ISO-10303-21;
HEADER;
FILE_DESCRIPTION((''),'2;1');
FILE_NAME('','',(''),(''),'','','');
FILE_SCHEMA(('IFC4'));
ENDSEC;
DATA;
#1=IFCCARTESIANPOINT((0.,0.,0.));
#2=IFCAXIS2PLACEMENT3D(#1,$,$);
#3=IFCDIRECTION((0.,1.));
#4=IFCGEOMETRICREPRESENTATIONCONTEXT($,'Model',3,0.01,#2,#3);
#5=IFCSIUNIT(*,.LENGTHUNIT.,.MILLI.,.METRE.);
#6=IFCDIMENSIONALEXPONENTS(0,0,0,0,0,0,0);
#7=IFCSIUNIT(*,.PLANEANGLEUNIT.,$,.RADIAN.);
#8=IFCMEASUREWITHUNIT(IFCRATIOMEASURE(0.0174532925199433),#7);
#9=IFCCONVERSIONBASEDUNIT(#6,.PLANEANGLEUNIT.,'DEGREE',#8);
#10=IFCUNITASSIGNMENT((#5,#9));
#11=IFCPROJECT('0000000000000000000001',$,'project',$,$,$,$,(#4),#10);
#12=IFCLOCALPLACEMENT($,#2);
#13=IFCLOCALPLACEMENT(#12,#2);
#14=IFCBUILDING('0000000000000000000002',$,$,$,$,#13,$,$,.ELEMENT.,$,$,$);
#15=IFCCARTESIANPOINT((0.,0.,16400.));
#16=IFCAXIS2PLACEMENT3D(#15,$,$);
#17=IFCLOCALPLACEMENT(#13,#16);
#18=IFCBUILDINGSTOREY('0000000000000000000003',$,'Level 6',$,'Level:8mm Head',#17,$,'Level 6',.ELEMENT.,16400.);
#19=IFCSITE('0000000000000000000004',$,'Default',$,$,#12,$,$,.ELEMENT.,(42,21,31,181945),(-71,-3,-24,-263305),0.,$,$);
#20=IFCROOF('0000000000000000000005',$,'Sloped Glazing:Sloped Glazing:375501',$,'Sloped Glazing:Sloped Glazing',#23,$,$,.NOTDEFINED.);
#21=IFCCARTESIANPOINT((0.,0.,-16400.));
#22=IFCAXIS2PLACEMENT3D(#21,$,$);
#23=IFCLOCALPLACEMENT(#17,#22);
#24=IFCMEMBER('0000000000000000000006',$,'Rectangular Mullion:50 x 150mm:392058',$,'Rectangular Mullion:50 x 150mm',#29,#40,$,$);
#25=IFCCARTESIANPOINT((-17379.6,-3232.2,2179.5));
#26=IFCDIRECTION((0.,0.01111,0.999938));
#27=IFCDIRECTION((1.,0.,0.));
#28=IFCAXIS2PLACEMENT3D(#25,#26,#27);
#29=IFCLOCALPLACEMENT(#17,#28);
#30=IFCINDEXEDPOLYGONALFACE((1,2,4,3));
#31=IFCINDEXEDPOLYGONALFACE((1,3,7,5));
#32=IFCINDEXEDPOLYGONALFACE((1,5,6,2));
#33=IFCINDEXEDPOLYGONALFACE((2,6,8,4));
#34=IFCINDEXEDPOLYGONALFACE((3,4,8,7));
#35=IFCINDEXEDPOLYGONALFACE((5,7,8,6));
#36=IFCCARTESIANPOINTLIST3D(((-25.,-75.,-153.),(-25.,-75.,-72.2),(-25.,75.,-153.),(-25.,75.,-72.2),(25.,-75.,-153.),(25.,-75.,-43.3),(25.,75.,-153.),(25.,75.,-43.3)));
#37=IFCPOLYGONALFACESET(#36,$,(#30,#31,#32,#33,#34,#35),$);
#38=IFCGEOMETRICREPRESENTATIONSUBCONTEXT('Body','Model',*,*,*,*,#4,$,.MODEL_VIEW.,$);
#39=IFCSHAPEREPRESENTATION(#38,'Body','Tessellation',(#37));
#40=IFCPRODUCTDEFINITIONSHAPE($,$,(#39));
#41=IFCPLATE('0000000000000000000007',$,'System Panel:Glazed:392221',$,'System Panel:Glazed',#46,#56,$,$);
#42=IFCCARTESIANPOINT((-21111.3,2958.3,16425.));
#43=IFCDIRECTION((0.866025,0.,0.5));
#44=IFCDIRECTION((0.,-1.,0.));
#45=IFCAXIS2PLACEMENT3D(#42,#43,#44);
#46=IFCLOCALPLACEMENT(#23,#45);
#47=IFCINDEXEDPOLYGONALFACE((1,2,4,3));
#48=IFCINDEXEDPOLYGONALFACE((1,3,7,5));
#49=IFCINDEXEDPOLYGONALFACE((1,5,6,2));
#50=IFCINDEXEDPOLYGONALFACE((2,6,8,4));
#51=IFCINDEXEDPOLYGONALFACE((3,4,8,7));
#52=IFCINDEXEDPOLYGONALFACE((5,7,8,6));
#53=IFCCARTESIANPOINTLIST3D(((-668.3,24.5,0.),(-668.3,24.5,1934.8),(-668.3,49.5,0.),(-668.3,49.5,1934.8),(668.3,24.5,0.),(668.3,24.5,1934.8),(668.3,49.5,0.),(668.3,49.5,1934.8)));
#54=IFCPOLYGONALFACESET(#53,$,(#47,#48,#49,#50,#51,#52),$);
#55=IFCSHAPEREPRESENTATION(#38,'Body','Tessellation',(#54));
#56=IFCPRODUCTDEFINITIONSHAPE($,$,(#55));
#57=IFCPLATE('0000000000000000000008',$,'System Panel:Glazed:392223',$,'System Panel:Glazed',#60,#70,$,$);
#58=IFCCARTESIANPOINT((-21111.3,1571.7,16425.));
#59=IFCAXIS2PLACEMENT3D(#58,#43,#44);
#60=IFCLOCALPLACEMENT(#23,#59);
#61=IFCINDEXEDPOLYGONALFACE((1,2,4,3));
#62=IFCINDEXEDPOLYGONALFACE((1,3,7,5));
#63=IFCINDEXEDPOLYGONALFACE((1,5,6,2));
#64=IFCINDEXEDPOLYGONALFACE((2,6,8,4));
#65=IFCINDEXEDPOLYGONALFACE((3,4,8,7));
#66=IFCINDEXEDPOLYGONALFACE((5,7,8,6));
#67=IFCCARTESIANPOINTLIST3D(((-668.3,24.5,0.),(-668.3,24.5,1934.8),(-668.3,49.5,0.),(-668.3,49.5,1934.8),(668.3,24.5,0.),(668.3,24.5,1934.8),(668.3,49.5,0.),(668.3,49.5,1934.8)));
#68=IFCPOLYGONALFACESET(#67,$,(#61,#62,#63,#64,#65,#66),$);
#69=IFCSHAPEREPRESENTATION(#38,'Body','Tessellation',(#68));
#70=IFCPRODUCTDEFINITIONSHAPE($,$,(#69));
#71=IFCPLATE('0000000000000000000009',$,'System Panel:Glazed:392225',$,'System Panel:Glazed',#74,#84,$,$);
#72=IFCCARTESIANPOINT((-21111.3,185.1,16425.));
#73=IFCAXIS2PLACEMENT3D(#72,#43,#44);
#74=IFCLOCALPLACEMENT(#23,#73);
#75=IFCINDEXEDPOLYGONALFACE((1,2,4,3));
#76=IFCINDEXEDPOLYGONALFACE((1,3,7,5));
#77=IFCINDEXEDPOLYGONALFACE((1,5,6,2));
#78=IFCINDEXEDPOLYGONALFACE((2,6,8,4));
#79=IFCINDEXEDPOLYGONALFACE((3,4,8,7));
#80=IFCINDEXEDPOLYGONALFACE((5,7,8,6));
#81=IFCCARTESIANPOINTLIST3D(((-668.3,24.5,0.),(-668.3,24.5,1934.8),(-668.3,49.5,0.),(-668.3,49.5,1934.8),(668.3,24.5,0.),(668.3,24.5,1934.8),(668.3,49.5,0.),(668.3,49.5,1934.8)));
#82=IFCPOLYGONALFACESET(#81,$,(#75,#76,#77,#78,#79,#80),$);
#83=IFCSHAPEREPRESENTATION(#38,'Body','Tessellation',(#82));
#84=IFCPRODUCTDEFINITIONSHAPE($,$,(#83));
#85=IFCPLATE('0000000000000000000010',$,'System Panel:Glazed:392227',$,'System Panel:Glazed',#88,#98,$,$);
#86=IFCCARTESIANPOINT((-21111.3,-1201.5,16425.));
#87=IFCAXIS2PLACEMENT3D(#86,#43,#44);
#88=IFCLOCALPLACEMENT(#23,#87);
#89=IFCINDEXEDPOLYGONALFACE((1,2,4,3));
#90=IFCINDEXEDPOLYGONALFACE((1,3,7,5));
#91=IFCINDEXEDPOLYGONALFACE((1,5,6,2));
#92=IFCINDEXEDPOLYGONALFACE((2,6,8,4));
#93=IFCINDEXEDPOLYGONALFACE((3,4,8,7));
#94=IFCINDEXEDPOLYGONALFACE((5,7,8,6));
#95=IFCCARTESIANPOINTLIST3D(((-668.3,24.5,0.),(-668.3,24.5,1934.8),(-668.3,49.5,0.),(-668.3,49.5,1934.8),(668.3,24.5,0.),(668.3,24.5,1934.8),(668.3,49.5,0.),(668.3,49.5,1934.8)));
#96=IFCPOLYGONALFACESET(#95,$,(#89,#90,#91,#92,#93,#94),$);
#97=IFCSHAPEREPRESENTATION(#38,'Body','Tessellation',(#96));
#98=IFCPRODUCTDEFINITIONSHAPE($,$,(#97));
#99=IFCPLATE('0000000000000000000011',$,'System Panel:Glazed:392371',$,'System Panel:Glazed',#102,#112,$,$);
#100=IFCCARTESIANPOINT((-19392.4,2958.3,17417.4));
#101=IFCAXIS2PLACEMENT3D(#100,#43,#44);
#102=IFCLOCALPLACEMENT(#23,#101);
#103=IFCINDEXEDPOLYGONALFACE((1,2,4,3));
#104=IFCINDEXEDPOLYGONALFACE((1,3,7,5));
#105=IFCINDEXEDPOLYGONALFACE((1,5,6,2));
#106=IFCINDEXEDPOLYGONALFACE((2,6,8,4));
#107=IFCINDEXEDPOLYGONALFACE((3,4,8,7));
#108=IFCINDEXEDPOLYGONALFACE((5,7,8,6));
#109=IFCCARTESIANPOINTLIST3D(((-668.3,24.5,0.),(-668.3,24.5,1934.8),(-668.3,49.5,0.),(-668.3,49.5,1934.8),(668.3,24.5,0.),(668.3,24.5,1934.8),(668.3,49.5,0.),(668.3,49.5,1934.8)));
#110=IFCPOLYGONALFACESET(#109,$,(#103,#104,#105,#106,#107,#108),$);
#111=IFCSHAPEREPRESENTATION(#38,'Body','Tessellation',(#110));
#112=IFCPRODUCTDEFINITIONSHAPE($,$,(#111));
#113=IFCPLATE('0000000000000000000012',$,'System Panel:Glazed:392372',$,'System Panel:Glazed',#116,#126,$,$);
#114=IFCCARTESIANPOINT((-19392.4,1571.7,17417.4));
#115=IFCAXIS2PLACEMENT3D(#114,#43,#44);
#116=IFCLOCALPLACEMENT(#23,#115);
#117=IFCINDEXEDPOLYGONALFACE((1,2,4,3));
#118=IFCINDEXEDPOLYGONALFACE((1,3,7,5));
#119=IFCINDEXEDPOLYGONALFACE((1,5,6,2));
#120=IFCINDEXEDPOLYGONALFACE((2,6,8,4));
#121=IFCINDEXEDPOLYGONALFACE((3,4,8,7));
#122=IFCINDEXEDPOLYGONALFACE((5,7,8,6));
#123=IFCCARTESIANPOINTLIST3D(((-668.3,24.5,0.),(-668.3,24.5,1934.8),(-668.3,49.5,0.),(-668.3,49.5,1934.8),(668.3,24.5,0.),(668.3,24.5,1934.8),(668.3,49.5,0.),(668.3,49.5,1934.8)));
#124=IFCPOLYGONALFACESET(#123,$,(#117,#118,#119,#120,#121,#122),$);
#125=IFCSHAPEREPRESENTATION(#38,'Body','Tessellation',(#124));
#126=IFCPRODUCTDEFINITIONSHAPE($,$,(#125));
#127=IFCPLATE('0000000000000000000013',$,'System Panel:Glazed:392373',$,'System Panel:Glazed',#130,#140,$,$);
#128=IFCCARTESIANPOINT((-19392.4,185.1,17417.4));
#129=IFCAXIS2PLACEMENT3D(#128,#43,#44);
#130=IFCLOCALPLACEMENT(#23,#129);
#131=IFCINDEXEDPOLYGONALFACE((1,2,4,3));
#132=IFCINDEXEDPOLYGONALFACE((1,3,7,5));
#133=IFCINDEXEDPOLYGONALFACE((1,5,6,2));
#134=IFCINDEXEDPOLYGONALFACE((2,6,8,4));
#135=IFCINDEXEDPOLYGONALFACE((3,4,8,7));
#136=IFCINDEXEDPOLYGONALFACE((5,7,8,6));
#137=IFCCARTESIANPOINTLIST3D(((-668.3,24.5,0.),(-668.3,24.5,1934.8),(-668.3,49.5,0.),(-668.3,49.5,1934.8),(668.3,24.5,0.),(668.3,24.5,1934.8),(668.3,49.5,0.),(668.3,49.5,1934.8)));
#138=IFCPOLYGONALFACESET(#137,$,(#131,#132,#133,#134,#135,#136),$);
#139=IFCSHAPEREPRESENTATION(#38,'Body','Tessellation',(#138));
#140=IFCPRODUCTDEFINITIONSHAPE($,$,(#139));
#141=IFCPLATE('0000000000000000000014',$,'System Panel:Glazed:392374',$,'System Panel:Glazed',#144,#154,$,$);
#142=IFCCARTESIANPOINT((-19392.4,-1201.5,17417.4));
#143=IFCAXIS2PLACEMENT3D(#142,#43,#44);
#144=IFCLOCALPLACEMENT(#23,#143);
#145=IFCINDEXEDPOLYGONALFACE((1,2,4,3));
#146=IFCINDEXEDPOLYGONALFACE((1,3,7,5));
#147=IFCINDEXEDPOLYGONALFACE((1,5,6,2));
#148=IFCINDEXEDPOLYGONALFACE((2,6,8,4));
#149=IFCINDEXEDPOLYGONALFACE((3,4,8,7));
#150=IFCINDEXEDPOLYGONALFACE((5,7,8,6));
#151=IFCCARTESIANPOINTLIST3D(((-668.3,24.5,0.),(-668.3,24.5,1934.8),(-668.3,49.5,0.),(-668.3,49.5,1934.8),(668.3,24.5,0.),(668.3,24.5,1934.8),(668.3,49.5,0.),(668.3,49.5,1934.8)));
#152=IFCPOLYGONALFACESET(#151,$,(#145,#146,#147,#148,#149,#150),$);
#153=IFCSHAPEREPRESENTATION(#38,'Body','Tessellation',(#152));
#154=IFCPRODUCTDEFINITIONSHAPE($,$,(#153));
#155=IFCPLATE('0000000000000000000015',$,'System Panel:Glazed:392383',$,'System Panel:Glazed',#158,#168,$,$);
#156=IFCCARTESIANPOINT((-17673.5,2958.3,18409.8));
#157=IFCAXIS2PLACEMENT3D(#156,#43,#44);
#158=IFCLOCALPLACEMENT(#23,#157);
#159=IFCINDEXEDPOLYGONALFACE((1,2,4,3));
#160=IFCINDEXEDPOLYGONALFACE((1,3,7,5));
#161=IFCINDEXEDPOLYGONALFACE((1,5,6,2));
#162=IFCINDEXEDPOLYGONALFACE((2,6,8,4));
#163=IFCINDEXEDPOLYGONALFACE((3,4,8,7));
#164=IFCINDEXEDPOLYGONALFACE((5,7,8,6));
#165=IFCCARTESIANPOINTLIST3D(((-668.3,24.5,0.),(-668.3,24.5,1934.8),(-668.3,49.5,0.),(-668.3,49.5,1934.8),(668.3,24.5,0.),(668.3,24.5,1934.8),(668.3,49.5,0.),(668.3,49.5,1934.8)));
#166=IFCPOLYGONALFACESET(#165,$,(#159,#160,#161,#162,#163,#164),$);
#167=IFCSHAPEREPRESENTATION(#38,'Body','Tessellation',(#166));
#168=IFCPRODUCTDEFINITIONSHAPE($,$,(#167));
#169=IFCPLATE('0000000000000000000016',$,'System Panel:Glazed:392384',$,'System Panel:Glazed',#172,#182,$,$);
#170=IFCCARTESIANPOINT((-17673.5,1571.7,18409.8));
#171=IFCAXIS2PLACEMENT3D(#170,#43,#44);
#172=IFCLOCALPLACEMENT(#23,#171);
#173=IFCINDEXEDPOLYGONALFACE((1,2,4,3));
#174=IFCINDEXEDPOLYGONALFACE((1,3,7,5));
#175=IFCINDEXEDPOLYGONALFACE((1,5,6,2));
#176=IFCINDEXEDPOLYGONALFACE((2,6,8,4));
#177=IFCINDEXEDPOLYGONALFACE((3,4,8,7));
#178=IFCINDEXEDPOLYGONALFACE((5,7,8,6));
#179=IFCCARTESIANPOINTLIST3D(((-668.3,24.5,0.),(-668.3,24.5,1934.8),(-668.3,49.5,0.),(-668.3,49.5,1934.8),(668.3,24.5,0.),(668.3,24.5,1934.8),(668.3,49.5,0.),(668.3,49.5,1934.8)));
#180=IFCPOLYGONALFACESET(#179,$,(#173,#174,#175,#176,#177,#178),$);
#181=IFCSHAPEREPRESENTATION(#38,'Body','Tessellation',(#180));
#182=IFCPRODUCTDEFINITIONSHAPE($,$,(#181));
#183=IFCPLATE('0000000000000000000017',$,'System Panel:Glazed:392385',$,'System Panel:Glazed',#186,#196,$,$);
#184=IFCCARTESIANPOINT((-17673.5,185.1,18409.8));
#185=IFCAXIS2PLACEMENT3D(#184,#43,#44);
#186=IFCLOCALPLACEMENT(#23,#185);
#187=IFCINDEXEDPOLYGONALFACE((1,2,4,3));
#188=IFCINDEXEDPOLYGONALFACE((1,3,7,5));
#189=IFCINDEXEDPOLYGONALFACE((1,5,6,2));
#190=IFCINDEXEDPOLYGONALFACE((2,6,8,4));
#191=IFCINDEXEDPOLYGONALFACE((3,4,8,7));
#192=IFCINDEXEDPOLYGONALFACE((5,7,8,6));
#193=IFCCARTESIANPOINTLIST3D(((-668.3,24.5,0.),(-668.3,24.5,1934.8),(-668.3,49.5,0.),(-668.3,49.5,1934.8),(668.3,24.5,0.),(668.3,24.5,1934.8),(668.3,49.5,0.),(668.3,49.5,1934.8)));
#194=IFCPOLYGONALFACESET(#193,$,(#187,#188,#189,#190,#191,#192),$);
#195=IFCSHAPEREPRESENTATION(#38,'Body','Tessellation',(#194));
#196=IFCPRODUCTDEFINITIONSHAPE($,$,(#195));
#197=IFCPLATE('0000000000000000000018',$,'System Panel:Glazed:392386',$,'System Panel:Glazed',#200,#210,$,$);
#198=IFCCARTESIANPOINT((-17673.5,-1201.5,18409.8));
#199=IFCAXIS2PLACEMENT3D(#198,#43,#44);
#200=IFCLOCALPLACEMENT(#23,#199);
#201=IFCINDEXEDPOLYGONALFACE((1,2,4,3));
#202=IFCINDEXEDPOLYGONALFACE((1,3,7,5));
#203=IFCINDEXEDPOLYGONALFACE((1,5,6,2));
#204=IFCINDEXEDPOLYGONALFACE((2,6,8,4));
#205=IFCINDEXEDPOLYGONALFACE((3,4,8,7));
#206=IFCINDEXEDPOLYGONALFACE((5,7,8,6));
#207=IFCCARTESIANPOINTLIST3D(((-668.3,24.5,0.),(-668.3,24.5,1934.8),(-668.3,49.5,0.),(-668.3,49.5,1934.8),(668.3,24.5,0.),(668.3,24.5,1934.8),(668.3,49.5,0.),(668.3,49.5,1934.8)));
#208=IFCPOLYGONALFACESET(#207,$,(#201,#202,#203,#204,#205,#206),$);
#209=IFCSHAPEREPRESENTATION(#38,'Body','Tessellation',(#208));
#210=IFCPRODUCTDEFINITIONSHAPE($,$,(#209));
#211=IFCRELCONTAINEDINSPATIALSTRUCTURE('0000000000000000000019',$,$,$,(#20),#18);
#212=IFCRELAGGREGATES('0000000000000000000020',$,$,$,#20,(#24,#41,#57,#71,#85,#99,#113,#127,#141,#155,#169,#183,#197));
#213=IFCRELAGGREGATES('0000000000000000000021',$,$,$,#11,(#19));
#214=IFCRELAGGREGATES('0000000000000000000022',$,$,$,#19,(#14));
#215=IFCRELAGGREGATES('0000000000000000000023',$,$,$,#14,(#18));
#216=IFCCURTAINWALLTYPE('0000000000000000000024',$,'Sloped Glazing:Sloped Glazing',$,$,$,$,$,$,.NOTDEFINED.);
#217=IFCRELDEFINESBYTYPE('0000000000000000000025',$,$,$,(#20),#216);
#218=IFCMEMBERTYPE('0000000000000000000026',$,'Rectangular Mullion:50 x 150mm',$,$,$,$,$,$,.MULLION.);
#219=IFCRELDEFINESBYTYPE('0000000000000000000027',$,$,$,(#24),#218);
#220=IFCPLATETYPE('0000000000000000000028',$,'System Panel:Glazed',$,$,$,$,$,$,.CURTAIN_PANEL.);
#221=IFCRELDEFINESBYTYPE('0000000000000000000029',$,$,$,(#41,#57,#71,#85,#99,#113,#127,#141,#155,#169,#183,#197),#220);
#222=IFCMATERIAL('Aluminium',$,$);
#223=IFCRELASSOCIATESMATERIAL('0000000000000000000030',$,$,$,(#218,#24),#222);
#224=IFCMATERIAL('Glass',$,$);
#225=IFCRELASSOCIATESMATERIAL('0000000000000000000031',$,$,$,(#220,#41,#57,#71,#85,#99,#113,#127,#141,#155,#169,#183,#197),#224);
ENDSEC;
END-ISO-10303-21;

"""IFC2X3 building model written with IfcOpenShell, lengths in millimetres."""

from ifc_helpers import new_model, entity, si_unit, converted_unit, direction, frame, frame_2d, origin, origin_2d_with_axis, place, context, subcontext, project, spatial, rectangle, extrude, clip, halfspace, source, transform, mapped, material, type_object, type_shapes, element, aggregate, save


model = new_model("IFC2X3")

# Units and contexts
model_context = context("Model", 3, precision=0.01, world=origin(), true_north=direction((0.0, 1.0)))
body_context = subcontext(model_context, "Body", "Model", "MODEL_VIEW")
ifc_project = project(units=[si_unit("LENGTHUNIT", "METRE", prefix="MILLI"), converted_unit("PLANEANGLEUNIT", "DEGREE", entity("IfcRatioMeasure", 0.0174532925199433), si_unit("PLANEANGLEUNIT", "RADIAN"), dimensions=[0, 0, 0, 0, 0, 0, 0])], contexts=[model_context])

# Site, building, storey
site_placement = place(None, frame((0.0, 0.0, 0.0)))
site = spatial("IfcSite", under=ifc_project, at=site_placement, Name="Default", CompositionType="ELEMENT", RefLatitude=(42, 21, 31, 181945), RefLongitude=(-71, -3, -24, -263305), RefElevation=0.0)
building_placement = place(site_placement, origin())
building = spatial("IfcBuilding", under=site, at=building_placement, CompositionType="ELEMENT")
storey_placement = place(building_placement, frame((0.0, 0.0, 16400.0)))
storey = spatial("IfcBuildingStorey", under=building, at=storey_placement, Name="Level 6", ObjectType="Level:8mm Head", LongName="Level 6", CompositionType="ELEMENT", Elevation=16400.0)

# Roof, member, plates
curtain_wall_type = type_object("IfcCurtainWallType", Name="Sloped Glazing:Sloped Glazing", PredefinedType="NOTDEFINED")
roof_placement = place(storey_placement, frame((0.0, 0.0, -16400.0)))
roof = element("IfcRoof", 1, at=roof_placement, inside=storey, type_object=curtain_wall_type, Name="Sloped Glazing:Sloped Glazing:375501", ObjectType="Sloped Glazing:Sloped Glazing", ShapeType="NOTDEFINED")
ifc_material_1 = material(Name="Aluminium")
member_type_1 = type_object("IfcMemberType", Name="Rectangular Mullion:50 x 150mm", PredefinedType="MULLION", material=ifc_material_1)
shared_shape_1 = source(origin(), body_context, "Body", "Clipping", [
    clip(extrude(rectangle(XDim=150.0, YDim=50.0, at=frame_2d((0.0, 0.0), x_axis=(1.0, 0.0))), frame((0.0, 0.0, -153.0), z_axis=(0.0, 0.0, 1.0), x_axis=(0.0, -1.0, 0.0)), (0.0, 0.0, 1.0), 109.7), halfspace(frame((-240.0, 75.0, -196.3), z_axis=(-0.500023, 0.0, 0.866012), x_axis=(0.866012, 0.0, 0.500023)), False)),
])
type_shapes(member_type_1, [shared_shape_1])
member_1_placement = place(storey_placement, frame((-17379.6, -3232.2, 2179.5), z_axis=(0.0, 0.01111, 0.999938), x_axis=(1.0, 0.0, 0.0)))
member_1 = element("IfcMember", 2, at=member_1_placement, type_object=member_type_1, material=ifc_material_1, Name="Rectangular Mullion:50 x 150mm:392058", ObjectType="Rectangular Mullion:50 x 150mm", context=body_context, shape_type="MappedRepresentation", body=[
    mapped(shared_shape_1, transform((0.0, 0.0, 0.0), scale=1.0)),
])
ifc_material_2 = material(Name="Glass")
plate_type_1 = type_object("IfcPlateType", Name="System Panel:Glazed", PredefinedType="CURTAIN_PANEL", material=ifc_material_2)
shared_shape_2 = source(origin(), body_context, "Body", "SweptSolid", [
    extrude(rectangle(XDim=25.0, YDim=1336.6, at=origin_2d_with_axis()), frame((0.0, 37.0, 0.0), z_axis=(0.0, 0.0, 1.0), x_axis=(0.0, 1.0, 0.0)), (0.0, 0.0, 1.0), 1934.8),
])
type_shapes(plate_type_1, [shared_shape_2])
plate_1_placement = place(roof_placement, frame((-21111.3, 2958.3, 16425.0), z_axis=(0.866025, 0.0, 0.5), x_axis=(0.0, -1.0, 0.0)))
plate_1 = element("IfcPlate", 3, at=plate_1_placement, type_object=plate_type_1, material=ifc_material_2, Name="System Panel:Glazed:392221", ObjectType="System Panel:Glazed", context=body_context, shape_type="MappedRepresentation", body=[
    mapped(shared_shape_2, transform((0.0, 0.0, 0.0), scale=1.0)),
])
plate_2_placement = place(roof_placement, frame((-21111.3, 1571.7, 16425.0), z_axis=(0.866025, 0.0, 0.5), x_axis=(0.0, -1.0, 0.0)))
plate_2 = element("IfcPlate", 4, at=plate_2_placement, type_object=plate_type_1, material=ifc_material_2, Name="System Panel:Glazed:392223", ObjectType="System Panel:Glazed", context=body_context, shape_type="MappedRepresentation", body=[
    mapped(shared_shape_2, transform((0.0, 0.0, 0.0), scale=1.0)),
])
plate_3_placement = place(roof_placement, frame((-21111.3, 185.1, 16425.0), z_axis=(0.866025, 0.0, 0.5), x_axis=(0.0, -1.0, 0.0)))
plate_3 = element("IfcPlate", 5, at=plate_3_placement, type_object=plate_type_1, material=ifc_material_2, Name="System Panel:Glazed:392225", ObjectType="System Panel:Glazed", context=body_context, shape_type="MappedRepresentation", body=[
    mapped(shared_shape_2, transform((0.0, 0.0, 0.0), scale=1.0)),
])
plate_4_placement = place(roof_placement, frame((-21111.3, -1201.5, 16425.0), z_axis=(0.866025, 0.0, 0.5), x_axis=(0.0, -1.0, 0.0)))
plate_4 = element("IfcPlate", 6, at=plate_4_placement, type_object=plate_type_1, material=ifc_material_2, Name="System Panel:Glazed:392227", ObjectType="System Panel:Glazed", context=body_context, shape_type="MappedRepresentation", body=[
    mapped(shared_shape_2, transform((0.0, 0.0, 0.0), scale=1.0)),
])
plate_5_placement = place(roof_placement, frame((-19392.4, 2958.3, 17417.4), z_axis=(0.866025, 0.0, 0.5), x_axis=(0.0, -1.0, 0.0)))
plate_5 = element("IfcPlate", 7, at=plate_5_placement, type_object=plate_type_1, material=ifc_material_2, Name="System Panel:Glazed:392371", ObjectType="System Panel:Glazed", context=body_context, shape_type="MappedRepresentation", body=[
    mapped(shared_shape_2, transform((0.0, 0.0, 0.0), scale=1.0)),
])
plate_6_placement = place(roof_placement, frame((-19392.4, 1571.7, 17417.4), z_axis=(0.866025, 0.0, 0.5), x_axis=(0.0, -1.0, 0.0)))
plate_6 = element("IfcPlate", 8, at=plate_6_placement, type_object=plate_type_1, material=ifc_material_2, Name="System Panel:Glazed:392372", ObjectType="System Panel:Glazed", context=body_context, shape_type="MappedRepresentation", body=[
    mapped(shared_shape_2, transform((0.0, 0.0, 0.0), scale=1.0)),
])
plate_7_placement = place(roof_placement, frame((-19392.4, 185.1, 17417.4), z_axis=(0.866025, 0.0, 0.5), x_axis=(0.0, -1.0, 0.0)))
plate_7 = element("IfcPlate", 9, at=plate_7_placement, type_object=plate_type_1, material=ifc_material_2, Name="System Panel:Glazed:392373", ObjectType="System Panel:Glazed", context=body_context, shape_type="MappedRepresentation", body=[
    mapped(shared_shape_2, transform((0.0, 0.0, 0.0), scale=1.0)),
])
plate_8_placement = place(roof_placement, frame((-19392.4, -1201.5, 17417.4), z_axis=(0.866025, 0.0, 0.5), x_axis=(0.0, -1.0, 0.0)))
plate_8 = element("IfcPlate", 10, at=plate_8_placement, type_object=plate_type_1, material=ifc_material_2, Name="System Panel:Glazed:392374", ObjectType="System Panel:Glazed", context=body_context, shape_type="MappedRepresentation", body=[
    mapped(shared_shape_2, transform((0.0, 0.0, 0.0), scale=1.0)),
])
plate_9_placement = place(roof_placement, frame((-17673.5, 2958.3, 18409.8), z_axis=(0.866025, 0.0, 0.5), x_axis=(0.0, -1.0, 0.0)))
plate_9 = element("IfcPlate", 11, at=plate_9_placement, type_object=plate_type_1, material=ifc_material_2, Name="System Panel:Glazed:392383", ObjectType="System Panel:Glazed", context=body_context, shape_type="MappedRepresentation", body=[
    mapped(shared_shape_2, transform((0.0, 0.0, 0.0), scale=1.0)),
])
plate_10_placement = place(roof_placement, frame((-17673.5, 1571.7, 18409.8), z_axis=(0.866025, 0.0, 0.5), x_axis=(0.0, -1.0, 0.0)))
plate_10 = element("IfcPlate", 12, at=plate_10_placement, type_object=plate_type_1, material=ifc_material_2, Name="System Panel:Glazed:392384", ObjectType="System Panel:Glazed", context=body_context, shape_type="MappedRepresentation", body=[
    mapped(shared_shape_2, transform((0.0, 0.0, 0.0), scale=1.0)),
])
plate_11_placement = place(roof_placement, frame((-17673.5, 185.1, 18409.8), z_axis=(0.866025, 0.0, 0.5), x_axis=(0.0, -1.0, 0.0)))
plate_11 = element("IfcPlate", 13, at=plate_11_placement, type_object=plate_type_1, material=ifc_material_2, Name="System Panel:Glazed:392385", ObjectType="System Panel:Glazed", context=body_context, shape_type="MappedRepresentation", body=[
    mapped(shared_shape_2, transform((0.0, 0.0, 0.0), scale=1.0)),
])
plate_12_placement = place(roof_placement, frame((-17673.5, -1201.5, 18409.8), z_axis=(0.866025, 0.0, 0.5), x_axis=(0.0, -1.0, 0.0)))
plate_12 = element("IfcPlate", 14, at=plate_12_placement, type_object=plate_type_1, material=ifc_material_2, Name="System Panel:Glazed:392386", ObjectType="System Panel:Glazed", context=body_context, shape_type="MappedRepresentation", body=[
    mapped(shared_shape_2, transform((0.0, 0.0, 0.0), scale=1.0)),
])
aggregate(roof, [member_1, plate_1, plate_2, plate_3, plate_4, plate_5, plate_6, plate_7, plate_8, plate_9, plate_10, plate_11, plate_12])

save(model, "model.ifc")
